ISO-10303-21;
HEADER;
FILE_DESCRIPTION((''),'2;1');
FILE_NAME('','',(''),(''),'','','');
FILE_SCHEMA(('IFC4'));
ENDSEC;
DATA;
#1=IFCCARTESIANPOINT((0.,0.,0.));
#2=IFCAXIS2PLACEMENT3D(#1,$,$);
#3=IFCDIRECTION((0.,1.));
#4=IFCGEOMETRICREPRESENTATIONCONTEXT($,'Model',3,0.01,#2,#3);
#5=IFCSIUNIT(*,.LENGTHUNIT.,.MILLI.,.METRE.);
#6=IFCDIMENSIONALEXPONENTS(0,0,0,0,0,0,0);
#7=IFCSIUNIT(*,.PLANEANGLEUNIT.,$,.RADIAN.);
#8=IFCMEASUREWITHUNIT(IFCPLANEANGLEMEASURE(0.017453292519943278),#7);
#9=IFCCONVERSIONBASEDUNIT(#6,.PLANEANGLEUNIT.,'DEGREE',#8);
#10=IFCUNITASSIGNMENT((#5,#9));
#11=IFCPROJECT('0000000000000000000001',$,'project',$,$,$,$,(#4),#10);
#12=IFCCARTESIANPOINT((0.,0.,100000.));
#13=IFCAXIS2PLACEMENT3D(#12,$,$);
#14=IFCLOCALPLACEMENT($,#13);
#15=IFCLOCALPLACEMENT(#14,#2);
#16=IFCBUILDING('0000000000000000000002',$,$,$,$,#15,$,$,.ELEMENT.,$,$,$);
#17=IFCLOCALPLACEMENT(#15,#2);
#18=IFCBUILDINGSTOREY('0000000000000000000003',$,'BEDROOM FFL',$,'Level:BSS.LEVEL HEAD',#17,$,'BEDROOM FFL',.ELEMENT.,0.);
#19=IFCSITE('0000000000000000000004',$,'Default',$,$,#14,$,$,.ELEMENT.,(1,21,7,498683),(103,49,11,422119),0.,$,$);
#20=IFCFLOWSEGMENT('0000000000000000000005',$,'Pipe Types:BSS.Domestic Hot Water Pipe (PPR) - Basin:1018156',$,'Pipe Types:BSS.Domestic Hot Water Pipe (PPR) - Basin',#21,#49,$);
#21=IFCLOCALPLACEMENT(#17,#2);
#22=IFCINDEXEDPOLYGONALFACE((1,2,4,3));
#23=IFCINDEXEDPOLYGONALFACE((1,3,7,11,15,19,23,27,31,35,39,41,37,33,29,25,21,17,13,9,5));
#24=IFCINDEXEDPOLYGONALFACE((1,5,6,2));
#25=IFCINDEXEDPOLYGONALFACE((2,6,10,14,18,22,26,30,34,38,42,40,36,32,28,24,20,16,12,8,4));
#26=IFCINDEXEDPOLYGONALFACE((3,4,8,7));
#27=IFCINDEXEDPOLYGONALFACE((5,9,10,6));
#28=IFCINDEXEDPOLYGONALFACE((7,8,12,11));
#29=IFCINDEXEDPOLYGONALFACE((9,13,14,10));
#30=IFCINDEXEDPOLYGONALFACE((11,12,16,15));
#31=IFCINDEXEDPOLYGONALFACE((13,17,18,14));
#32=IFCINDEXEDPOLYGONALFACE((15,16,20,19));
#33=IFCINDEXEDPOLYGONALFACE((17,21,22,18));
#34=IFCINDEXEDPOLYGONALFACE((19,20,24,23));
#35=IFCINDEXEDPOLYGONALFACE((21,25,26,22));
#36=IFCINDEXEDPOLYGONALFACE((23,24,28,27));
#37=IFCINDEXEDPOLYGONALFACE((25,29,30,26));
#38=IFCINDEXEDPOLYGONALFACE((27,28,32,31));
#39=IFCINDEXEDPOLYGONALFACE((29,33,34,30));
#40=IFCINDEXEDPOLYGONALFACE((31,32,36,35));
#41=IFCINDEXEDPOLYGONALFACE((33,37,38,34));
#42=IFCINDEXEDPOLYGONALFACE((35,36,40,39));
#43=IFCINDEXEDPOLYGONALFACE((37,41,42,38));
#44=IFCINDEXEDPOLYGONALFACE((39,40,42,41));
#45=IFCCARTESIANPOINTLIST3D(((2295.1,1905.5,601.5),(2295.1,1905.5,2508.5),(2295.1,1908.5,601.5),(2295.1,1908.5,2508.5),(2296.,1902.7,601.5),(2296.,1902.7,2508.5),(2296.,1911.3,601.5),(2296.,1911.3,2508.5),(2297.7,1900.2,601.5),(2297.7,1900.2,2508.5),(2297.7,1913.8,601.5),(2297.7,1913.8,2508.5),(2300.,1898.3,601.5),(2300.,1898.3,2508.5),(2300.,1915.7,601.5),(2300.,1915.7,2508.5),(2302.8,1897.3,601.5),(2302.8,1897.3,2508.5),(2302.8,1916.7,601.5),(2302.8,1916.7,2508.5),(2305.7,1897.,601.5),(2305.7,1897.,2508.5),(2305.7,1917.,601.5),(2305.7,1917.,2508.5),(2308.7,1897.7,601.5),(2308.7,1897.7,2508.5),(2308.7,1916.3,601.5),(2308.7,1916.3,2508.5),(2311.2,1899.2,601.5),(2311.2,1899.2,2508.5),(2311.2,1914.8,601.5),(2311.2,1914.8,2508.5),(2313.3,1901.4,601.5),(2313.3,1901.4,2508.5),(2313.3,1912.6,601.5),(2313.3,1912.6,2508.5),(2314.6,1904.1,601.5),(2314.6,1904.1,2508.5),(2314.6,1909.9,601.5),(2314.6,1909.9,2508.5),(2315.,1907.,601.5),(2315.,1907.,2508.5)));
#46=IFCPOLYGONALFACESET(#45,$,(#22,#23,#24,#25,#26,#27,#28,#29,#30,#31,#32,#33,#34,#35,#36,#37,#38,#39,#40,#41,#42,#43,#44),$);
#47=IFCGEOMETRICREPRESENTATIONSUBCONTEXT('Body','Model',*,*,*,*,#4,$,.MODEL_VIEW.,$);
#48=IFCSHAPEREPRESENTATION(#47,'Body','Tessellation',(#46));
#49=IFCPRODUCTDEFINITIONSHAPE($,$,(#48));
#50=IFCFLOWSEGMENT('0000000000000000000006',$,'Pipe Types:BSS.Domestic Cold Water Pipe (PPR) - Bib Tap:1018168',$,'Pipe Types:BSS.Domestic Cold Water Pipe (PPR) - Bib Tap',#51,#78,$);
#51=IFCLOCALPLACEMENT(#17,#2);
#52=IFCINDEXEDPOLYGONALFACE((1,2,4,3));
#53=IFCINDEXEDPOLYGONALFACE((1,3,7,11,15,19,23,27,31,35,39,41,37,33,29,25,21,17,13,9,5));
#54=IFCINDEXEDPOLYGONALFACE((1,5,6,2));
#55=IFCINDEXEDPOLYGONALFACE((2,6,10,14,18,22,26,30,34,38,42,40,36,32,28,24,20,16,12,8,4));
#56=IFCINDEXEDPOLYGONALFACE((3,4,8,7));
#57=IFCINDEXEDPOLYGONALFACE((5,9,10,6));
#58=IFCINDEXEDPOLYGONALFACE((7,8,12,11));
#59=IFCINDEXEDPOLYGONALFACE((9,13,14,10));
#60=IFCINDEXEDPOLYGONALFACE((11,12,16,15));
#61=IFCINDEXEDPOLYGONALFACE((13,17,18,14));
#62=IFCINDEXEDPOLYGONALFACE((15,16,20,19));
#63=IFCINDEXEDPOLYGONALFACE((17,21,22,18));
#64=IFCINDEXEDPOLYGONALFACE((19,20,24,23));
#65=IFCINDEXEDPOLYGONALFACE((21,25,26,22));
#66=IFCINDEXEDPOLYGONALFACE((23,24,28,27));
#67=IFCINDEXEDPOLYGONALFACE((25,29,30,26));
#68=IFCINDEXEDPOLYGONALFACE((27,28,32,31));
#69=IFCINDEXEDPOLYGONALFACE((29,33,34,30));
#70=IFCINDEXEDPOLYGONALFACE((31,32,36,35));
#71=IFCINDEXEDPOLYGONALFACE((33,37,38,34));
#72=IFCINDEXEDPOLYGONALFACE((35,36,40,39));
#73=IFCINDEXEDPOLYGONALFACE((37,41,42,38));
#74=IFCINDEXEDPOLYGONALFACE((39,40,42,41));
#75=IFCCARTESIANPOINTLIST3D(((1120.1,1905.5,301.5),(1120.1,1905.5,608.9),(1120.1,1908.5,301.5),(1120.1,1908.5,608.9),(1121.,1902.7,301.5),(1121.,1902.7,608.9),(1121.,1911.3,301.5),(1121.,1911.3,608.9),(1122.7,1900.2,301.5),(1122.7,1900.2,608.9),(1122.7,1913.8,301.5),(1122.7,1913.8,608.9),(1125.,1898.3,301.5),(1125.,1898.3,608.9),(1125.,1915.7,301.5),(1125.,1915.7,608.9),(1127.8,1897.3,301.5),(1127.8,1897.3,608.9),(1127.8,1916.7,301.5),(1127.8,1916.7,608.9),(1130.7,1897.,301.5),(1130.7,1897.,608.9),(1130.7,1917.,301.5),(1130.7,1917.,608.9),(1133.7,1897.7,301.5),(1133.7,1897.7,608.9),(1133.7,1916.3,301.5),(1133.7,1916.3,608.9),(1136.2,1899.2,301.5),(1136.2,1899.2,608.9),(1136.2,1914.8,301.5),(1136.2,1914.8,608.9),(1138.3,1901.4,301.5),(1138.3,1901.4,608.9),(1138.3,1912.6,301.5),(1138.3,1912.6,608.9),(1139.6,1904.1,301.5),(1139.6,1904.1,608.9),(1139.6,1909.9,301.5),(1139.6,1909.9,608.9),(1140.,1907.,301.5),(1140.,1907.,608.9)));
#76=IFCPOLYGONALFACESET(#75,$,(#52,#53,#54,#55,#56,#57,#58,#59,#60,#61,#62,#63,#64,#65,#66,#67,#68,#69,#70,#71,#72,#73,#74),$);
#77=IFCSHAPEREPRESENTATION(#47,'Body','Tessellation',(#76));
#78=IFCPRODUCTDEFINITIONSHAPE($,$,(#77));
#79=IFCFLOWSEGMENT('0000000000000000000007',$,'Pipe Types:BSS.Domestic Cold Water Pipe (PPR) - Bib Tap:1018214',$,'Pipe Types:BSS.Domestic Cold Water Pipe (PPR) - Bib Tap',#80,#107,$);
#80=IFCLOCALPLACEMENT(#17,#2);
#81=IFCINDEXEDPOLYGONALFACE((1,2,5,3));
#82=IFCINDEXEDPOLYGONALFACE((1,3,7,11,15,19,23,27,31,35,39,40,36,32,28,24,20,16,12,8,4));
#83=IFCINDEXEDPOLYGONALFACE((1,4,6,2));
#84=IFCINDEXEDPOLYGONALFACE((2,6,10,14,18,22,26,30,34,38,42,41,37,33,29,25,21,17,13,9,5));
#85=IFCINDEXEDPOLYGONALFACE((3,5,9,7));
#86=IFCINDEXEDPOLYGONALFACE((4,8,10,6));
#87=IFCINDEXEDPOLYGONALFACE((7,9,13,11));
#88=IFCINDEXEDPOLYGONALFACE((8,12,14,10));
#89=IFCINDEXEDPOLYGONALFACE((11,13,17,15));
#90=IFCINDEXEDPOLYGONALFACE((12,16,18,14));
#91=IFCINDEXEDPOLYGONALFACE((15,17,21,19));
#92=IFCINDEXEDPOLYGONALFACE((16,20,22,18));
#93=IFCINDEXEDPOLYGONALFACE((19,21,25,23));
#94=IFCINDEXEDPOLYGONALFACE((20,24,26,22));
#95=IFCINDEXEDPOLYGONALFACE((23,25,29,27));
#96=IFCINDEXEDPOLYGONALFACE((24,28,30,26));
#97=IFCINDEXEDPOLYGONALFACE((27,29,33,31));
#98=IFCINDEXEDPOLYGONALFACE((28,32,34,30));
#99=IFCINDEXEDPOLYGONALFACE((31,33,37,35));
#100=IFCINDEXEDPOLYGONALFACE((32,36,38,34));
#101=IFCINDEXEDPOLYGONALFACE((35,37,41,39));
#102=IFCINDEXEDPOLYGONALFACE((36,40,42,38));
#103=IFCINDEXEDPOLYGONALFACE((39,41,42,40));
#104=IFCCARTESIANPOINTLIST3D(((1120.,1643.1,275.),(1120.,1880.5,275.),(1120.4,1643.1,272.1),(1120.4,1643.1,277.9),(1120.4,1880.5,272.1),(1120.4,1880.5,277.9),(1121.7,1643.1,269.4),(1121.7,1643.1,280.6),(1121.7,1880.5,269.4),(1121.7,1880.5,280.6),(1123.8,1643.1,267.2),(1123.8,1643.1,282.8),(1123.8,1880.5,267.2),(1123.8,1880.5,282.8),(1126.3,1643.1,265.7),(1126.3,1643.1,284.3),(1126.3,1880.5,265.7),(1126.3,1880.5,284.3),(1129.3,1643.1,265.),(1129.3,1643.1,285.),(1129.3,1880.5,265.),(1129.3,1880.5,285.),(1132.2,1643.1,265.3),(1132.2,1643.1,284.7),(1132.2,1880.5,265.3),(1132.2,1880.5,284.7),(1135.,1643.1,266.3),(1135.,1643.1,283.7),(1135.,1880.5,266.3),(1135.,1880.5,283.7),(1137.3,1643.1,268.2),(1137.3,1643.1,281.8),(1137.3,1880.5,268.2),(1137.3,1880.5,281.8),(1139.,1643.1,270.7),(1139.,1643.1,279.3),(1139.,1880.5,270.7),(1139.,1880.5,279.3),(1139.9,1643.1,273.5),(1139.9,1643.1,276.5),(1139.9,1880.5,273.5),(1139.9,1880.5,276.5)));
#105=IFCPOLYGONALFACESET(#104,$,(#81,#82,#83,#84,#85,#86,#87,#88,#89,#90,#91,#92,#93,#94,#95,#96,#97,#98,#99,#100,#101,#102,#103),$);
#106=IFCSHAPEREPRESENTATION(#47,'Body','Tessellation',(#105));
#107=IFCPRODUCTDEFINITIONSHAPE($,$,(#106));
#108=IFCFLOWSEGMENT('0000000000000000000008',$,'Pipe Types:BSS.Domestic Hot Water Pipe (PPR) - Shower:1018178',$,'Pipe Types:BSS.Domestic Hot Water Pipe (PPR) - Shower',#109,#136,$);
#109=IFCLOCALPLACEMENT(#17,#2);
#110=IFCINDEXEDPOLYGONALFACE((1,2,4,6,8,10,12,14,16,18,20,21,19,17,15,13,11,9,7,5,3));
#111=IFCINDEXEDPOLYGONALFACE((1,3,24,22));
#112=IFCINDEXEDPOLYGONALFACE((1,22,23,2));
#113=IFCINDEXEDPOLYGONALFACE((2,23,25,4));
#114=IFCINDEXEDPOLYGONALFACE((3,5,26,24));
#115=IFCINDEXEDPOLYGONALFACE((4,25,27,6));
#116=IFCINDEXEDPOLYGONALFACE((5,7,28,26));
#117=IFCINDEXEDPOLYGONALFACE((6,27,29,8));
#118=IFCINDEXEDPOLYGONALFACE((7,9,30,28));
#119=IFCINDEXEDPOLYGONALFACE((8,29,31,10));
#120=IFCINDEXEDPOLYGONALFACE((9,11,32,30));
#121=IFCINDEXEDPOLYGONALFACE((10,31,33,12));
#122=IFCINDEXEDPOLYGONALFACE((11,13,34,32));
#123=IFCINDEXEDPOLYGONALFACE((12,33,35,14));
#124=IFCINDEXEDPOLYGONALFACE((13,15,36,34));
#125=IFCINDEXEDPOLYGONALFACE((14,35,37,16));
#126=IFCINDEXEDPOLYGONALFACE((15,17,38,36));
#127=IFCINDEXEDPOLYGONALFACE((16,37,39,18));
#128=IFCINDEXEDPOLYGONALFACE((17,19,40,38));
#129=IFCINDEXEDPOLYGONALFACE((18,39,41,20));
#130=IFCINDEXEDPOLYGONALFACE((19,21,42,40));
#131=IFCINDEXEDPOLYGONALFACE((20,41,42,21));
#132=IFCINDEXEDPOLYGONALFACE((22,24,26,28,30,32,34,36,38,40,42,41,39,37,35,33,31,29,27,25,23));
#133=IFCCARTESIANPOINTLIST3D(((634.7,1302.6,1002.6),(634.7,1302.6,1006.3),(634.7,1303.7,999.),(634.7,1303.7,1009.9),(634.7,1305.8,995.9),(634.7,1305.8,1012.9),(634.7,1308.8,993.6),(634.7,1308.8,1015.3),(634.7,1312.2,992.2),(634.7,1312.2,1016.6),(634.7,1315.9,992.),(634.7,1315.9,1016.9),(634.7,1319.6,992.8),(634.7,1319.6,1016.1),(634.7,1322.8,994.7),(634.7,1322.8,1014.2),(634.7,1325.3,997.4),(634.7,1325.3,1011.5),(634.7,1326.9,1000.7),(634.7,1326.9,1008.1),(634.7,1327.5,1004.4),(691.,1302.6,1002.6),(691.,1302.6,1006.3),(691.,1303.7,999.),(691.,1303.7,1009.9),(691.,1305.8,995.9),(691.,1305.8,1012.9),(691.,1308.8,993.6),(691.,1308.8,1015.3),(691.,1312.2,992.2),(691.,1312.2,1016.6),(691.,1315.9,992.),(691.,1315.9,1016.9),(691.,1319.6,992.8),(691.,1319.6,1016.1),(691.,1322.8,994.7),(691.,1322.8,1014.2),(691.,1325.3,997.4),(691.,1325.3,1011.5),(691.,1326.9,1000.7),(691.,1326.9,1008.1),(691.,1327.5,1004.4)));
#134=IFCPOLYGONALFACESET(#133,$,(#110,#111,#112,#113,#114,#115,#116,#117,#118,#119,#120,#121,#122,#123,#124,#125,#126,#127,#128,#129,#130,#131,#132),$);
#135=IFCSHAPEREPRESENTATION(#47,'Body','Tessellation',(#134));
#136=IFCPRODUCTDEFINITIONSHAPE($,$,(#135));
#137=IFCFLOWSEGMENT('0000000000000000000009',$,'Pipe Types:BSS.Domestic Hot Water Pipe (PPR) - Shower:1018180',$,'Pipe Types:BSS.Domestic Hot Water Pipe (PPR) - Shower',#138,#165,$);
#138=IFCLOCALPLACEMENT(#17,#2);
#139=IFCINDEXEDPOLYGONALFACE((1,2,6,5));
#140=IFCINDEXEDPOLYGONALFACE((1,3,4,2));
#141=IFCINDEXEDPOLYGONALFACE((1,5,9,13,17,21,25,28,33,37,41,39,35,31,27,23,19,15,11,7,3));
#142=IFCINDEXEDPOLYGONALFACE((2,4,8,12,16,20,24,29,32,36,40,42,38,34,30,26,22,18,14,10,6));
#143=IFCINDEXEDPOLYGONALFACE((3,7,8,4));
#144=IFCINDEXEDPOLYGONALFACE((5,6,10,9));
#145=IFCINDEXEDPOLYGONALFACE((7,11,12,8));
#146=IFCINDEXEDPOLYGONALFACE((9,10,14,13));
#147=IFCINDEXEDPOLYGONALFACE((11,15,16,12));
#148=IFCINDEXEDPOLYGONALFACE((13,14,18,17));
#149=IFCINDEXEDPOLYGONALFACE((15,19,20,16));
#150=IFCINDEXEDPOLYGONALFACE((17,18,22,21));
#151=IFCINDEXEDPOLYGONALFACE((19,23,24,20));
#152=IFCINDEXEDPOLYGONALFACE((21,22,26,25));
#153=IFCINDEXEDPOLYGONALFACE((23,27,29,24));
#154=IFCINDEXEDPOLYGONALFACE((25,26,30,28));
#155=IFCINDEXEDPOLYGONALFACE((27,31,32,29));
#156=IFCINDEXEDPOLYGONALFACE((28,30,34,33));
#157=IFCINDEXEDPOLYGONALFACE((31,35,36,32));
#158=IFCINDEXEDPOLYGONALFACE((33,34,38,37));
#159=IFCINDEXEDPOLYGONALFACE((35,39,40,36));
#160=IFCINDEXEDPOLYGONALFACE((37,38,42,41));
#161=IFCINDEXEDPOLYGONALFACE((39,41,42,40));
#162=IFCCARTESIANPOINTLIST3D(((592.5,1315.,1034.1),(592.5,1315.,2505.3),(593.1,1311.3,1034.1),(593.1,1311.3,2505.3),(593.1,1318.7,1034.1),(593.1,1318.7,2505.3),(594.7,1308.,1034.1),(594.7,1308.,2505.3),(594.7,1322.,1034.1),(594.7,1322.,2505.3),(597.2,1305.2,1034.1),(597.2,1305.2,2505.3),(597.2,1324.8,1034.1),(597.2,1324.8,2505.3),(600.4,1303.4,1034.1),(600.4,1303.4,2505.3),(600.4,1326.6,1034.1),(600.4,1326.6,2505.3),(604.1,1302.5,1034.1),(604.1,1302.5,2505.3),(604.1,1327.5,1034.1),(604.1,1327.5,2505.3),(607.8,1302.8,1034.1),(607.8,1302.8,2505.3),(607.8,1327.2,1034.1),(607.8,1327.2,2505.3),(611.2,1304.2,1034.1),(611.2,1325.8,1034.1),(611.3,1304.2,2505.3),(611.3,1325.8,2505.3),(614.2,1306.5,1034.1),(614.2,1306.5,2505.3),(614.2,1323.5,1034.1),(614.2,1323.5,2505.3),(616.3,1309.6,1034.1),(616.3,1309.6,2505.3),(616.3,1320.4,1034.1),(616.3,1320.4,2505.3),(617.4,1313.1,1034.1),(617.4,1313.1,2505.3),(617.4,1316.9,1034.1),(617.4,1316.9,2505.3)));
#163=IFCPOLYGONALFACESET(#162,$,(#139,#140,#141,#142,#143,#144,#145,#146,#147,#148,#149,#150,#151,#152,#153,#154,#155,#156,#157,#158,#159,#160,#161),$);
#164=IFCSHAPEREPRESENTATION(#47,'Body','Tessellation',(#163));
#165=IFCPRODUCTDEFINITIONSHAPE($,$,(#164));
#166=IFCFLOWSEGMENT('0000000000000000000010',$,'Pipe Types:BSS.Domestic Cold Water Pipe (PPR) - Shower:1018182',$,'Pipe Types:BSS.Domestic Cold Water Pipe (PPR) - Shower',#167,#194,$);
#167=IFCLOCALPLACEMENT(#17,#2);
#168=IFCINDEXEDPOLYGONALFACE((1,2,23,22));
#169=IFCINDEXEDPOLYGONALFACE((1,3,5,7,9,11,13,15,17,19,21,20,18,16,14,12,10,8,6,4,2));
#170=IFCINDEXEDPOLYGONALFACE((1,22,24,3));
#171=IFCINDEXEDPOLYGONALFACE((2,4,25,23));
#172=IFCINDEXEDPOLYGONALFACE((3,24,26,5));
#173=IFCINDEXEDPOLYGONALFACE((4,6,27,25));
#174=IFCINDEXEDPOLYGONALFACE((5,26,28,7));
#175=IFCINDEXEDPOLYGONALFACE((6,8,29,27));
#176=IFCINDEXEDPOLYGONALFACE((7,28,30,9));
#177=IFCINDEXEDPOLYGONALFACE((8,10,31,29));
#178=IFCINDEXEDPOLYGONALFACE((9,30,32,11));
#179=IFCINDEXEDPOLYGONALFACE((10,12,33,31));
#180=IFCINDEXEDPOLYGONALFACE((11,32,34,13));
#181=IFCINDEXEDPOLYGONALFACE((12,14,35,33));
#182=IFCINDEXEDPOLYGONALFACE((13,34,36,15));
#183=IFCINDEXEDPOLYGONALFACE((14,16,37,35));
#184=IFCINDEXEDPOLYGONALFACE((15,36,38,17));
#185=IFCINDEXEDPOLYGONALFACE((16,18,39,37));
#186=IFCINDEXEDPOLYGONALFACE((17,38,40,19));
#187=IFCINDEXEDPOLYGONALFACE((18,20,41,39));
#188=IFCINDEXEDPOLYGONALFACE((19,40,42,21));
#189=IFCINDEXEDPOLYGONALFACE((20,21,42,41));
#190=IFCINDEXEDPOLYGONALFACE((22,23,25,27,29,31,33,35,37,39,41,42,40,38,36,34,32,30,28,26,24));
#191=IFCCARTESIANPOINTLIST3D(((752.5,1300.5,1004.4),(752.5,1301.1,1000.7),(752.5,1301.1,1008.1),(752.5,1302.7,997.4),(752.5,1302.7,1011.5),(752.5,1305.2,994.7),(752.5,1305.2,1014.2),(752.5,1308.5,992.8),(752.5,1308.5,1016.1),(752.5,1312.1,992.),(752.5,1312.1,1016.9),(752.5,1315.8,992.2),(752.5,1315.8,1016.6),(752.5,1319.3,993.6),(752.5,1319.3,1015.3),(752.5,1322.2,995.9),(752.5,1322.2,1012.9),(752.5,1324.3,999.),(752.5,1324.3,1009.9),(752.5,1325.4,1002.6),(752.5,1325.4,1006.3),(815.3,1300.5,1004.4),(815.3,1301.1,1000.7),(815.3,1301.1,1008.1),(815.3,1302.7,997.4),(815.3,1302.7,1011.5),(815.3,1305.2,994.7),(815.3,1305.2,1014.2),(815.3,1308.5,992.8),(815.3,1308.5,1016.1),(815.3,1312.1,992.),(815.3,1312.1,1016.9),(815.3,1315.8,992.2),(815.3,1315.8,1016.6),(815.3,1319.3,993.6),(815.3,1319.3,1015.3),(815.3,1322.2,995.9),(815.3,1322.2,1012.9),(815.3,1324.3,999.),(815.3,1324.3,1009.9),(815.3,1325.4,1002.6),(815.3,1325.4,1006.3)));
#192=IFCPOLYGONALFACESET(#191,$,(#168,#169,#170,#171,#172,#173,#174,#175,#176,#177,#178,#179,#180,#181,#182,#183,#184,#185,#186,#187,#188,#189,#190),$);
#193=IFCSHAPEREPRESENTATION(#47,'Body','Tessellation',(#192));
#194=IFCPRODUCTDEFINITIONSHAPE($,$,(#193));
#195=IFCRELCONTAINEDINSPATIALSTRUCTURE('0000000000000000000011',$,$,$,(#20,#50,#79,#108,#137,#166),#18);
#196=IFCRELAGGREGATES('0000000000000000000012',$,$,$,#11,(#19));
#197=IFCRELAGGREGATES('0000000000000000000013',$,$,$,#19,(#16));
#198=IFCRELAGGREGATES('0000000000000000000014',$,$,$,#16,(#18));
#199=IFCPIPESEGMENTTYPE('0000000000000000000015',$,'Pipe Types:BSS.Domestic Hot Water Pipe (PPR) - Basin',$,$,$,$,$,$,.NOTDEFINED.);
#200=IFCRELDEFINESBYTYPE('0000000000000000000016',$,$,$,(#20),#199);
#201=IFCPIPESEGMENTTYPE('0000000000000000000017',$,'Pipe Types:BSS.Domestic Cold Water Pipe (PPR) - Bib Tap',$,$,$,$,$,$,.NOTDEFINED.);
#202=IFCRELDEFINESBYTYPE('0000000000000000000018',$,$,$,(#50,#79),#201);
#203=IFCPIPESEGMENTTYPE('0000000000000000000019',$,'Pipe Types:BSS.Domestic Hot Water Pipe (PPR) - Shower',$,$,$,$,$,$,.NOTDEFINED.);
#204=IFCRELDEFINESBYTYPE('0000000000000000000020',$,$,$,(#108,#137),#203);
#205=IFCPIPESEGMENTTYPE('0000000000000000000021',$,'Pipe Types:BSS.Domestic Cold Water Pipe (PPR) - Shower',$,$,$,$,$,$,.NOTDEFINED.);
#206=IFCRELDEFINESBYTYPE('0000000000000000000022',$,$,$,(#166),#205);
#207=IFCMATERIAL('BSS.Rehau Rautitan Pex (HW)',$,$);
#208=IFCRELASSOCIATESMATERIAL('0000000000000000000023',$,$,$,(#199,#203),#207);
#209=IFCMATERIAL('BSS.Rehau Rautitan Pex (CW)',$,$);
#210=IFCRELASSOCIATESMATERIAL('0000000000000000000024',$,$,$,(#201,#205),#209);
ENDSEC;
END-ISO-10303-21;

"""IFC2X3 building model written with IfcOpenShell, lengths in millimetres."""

from ifc_helpers import new_model, entity, si_unit, converted_unit, direction, frame, frame_2d, origin, origin_2d_with_axis, place, context, subcontext, project, spatial, circle, extrude, material, type_object, element, save


model = new_model("IFC2X3")

# Units and contexts
model_context = context("Model", 3, precision=0.01, world=origin(), true_north=direction((0.0, 1.0)))
body_context = subcontext(model_context, "Body", "Model", "MODEL_VIEW")
ifc_project = project(units=[si_unit("LENGTHUNIT", "METRE", prefix="MILLI"), converted_unit("PLANEANGLEUNIT", "DEGREE", entity("IfcPlaneAngleMeasure", 0.017453292519943278), si_unit("PLANEANGLEUNIT", "RADIAN"), dimensions=[0, 0, 0, 0, 0, 0, 0])], contexts=[model_context])

# Site, building, storey
site_placement = place(None, frame((0.0, 0.0, 100000.0)))
site = spatial("IfcSite", under=ifc_project, at=site_placement, Name="Default", CompositionType="ELEMENT", RefLatitude=(1, 21, 7, 498683), RefLongitude=(103, 49, 11, 422119), RefElevation=0.0)
building_placement = place(site_placement, origin())
building = spatial("IfcBuilding", under=site, at=building_placement, CompositionType="ELEMENT")
storey_placement = place(building_placement, origin())
storey = spatial("IfcBuildingStorey", under=building, at=storey_placement, Name="BEDROOM FFL", ObjectType="Level:BSS.LEVEL HEAD", LongName="BEDROOM FFL", CompositionType="ELEMENT", Elevation=0.0)

# Flow segments
ifc_material_1 = material(Name="BSS.Rehau Rautitan Pex (HW)")
pipe_segment_type_1 = type_object("IfcPipeSegmentType", Name="Pipe Types:BSS.Domestic Hot Water Pipe (PPR) - Basin", PredefinedType="NOTDEFINED", material=ifc_material_1)
flow_segment_1_placement = place(storey_placement, origin())
element("IfcFlowSegment", 1, at=flow_segment_1_placement, inside=storey, type_object=pipe_segment_type_1, Name="Pipe Types:BSS.Domestic Hot Water Pipe (PPR) - Basin:1018156", ObjectType="Pipe Types:BSS.Domestic Hot Water Pipe (PPR) - Basin", context=body_context, shape_type="SweptSolid", body=[
    extrude(circle(Radius=10.0, at=frame_2d((0.0, 0.0), x_axis=(1.0, 0.0))), frame((2305.0, 1907.0, 601.5)), (0.0, 0.0, 1.0), 1907.0),
])
ifc_material_2 = material(Name="BSS.Rehau Rautitan Pex (CW)")
pipe_segment_type_2 = type_object("IfcPipeSegmentType", Name="Pipe Types:BSS.Domestic Cold Water Pipe (PPR) - Bib Tap", PredefinedType="NOTDEFINED", material=ifc_material_2)
flow_segment_2_placement = place(storey_placement, origin())
element("IfcFlowSegment", 2, at=flow_segment_2_placement, inside=storey, type_object=pipe_segment_type_2, Name="Pipe Types:BSS.Domestic Cold Water Pipe (PPR) - Bib Tap:1018168", ObjectType="Pipe Types:BSS.Domestic Cold Water Pipe (PPR) - Bib Tap", context=body_context, shape_type="SweptSolid", body=[
    extrude(circle(Radius=10.0, at=origin_2d_with_axis()), frame((1130.0, 1907.0, 301.5)), (0.0, 0.0, 1.0), 307.4),
])
flow_segment_3_placement = place(storey_placement, origin())
element("IfcFlowSegment", 3, at=flow_segment_3_placement, inside=storey, type_object=pipe_segment_type_2, Name="Pipe Types:BSS.Domestic Cold Water Pipe (PPR) - Bib Tap:1018214", ObjectType="Pipe Types:BSS.Domestic Cold Water Pipe (PPR) - Bib Tap", context=body_context, shape_type="SweptSolid", body=[
    extrude(circle(Radius=10.0, at=frame_2d((0.0, 0.0), x_axis=(1.0, 0.0))), frame((1130.0, 1643.1, 275.0), z_axis=(0.0, 1.0, 0.0), x_axis=(-1.0, 0.0, 0.0)), (0.0, 0.0, 1.0), 237.4),
])
pipe_segment_type_3 = type_object("IfcPipeSegmentType", Name="Pipe Types:BSS.Domestic Hot Water Pipe (PPR) - Shower", PredefinedType="NOTDEFINED", material=ifc_material_1)
flow_segment_4_placement = place(storey_placement, origin())
element("IfcFlowSegment", 4, at=flow_segment_4_placement, inside=storey, type_object=pipe_segment_type_3, Name="Pipe Types:BSS.Domestic Hot Water Pipe (PPR) - Shower:1018178", ObjectType="Pipe Types:BSS.Domestic Hot Water Pipe (PPR) - Shower", context=body_context, shape_type="SweptSolid", body=[
    extrude(circle(Radius=12.5, at=frame_2d((0.0, 0.0), x_axis=(1.0, 0.0))), frame((634.7, 1315.0, 1004.4), z_axis=(1.0, 0.0, 0.0), x_axis=(0.0, 1.0, 0.0)), (0.0, 0.0, 1.0), 56.3),
])
flow_segment_5_placement = place(storey_placement, origin())
element("IfcFlowSegment", 5, at=flow_segment_5_placement, inside=storey, type_object=pipe_segment_type_3, Name="Pipe Types:BSS.Domestic Hot Water Pipe (PPR) - Shower:1018180", ObjectType="Pipe Types:BSS.Domestic Hot Water Pipe (PPR) - Shower", context=body_context, shape_type="SweptSolid", body=[
    extrude(circle(Radius=12.5, at=origin_2d_with_axis()), frame((605.0, 1315.0, 1034.1), z_axis=(0.000002, 0.0, 1.0), x_axis=(-1.0, 0.0, 0.000002)), (0.0, 0.0, 1.0), 1471.2),
])
pipe_segment_type_4 = type_object("IfcPipeSegmentType", Name="Pipe Types:BSS.Domestic Cold Water Pipe (PPR) - Shower", PredefinedType="NOTDEFINED", material=ifc_material_2)
flow_segment_6_placement = place(storey_placement, origin())
element("IfcFlowSegment", 6, at=flow_segment_6_placement, inside=storey, type_object=pipe_segment_type_4, Name="Pipe Types:BSS.Domestic Cold Water Pipe (PPR) - Shower:1018182", ObjectType="Pipe Types:BSS.Domestic Cold Water Pipe (PPR) - Shower", context=body_context, shape_type="SweptSolid", body=[
    extrude(circle(Radius=12.5, at=origin_2d_with_axis()), frame((752.5, 1313.0, 1004.4), z_axis=(1.0, 0.0, 0.0), x_axis=(0.0, -1.0, 0.0)), (0.0, 0.0, 1.0), 62.8),
])

save(model, "model.ifc")
